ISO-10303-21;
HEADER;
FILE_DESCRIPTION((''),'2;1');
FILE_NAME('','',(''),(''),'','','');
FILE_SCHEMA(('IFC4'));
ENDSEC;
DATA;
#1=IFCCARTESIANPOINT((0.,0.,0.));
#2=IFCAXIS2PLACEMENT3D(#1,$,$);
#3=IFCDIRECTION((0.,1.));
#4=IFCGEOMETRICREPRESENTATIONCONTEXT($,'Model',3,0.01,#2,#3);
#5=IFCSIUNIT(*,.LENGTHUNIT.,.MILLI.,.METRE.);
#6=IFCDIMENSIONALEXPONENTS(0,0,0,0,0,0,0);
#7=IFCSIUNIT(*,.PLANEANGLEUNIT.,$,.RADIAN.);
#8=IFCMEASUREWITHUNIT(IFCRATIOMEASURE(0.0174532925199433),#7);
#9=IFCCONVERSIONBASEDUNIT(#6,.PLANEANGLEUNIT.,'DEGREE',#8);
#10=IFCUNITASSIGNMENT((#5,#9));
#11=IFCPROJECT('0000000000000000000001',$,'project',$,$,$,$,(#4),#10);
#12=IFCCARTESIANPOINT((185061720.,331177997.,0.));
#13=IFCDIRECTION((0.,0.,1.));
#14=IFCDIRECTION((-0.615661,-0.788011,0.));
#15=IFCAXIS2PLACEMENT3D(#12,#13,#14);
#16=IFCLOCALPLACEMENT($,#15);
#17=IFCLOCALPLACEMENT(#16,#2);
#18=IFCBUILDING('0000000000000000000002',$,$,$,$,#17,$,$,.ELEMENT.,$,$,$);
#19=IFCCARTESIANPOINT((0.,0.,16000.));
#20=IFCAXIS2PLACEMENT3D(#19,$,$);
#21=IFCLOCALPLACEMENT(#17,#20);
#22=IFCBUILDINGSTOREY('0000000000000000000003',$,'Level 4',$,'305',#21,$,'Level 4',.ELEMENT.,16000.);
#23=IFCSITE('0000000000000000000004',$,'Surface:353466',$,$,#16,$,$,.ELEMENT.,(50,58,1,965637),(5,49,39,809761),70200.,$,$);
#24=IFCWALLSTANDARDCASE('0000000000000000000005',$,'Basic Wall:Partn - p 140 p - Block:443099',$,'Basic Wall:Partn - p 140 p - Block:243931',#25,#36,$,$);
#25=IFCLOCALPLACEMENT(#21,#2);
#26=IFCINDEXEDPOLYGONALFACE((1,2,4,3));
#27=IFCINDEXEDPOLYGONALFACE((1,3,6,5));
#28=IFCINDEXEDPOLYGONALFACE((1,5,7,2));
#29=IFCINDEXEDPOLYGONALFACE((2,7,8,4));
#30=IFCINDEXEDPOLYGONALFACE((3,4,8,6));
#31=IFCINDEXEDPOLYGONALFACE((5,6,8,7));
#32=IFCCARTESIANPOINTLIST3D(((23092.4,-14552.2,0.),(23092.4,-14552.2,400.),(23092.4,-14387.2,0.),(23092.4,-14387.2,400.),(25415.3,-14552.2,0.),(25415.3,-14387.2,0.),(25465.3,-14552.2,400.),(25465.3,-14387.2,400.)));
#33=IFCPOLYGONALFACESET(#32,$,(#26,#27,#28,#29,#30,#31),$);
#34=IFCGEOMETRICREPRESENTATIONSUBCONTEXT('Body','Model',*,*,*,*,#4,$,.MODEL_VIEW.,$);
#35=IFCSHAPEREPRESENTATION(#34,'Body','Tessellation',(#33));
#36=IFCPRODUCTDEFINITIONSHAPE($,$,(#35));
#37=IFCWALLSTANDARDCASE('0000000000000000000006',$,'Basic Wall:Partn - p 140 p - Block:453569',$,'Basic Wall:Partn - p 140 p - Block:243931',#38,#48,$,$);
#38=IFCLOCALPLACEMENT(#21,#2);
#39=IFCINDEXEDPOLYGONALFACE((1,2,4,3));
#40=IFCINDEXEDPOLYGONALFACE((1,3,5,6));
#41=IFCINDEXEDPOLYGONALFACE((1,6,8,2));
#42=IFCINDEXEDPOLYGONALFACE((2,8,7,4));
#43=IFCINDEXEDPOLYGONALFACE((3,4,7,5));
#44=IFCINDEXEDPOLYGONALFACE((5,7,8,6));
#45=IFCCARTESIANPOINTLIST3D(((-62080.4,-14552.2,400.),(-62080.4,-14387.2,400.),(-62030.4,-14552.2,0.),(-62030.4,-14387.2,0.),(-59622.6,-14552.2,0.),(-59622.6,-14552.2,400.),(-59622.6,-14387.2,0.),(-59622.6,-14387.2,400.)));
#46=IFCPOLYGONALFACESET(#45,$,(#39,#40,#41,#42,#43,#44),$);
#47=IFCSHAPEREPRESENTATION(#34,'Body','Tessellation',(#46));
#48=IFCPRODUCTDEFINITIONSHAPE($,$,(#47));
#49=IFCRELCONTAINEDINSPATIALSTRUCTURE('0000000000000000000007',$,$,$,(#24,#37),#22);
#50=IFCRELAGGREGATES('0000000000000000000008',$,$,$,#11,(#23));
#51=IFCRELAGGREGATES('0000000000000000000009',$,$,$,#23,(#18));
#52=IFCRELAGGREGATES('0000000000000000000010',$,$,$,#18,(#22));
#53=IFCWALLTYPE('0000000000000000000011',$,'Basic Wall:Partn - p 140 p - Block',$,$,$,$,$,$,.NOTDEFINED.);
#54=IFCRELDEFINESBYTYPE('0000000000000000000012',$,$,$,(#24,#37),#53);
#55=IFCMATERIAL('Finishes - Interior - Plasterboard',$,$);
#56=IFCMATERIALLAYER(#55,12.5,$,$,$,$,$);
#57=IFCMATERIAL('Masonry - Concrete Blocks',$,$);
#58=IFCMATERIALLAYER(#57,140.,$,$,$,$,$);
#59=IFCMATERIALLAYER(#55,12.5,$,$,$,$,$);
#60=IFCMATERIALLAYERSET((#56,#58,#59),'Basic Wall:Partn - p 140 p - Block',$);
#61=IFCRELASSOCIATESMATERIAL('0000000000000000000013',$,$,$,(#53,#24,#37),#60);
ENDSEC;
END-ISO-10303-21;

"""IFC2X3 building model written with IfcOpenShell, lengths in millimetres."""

from ifc_helpers import new_model, entity, si_unit, converted_unit, direction, frame, frame_2d, origin, place, context, subcontext, project, spatial, polyline, rectangle, extrude, clip, halfspace, bounded_halfspace, material, layer, layer_set, layer_usage, type_object, element, save


model = new_model("IFC2X3")

# Units and contexts
model_context = context("Model", 3, precision=0.01, world=origin(), true_north=direction((0.0, 1.0)))
body_context = subcontext(model_context, "Body", "Model", "MODEL_VIEW")
ifc_project = project(units=[si_unit("LENGTHUNIT", "METRE", prefix="MILLI"), converted_unit("PLANEANGLEUNIT", "DEGREE", entity("IfcRatioMeasure", 0.0174532925199433), si_unit("PLANEANGLEUNIT", "RADIAN"), dimensions=[0, 0, 0, 0, 0, 0, 0])], contexts=[model_context])

# Site, building, storey
site_placement = place(None, frame((185061720.0, 331177997.0, 0.0), z_axis=(0.0, 0.0, 1.0), x_axis=(-0.615661, -0.788011, 0.0)))
site = spatial("IfcSite", under=ifc_project, at=site_placement, Name="Surface:353466", CompositionType="ELEMENT", RefLatitude=(50, 58, 1, 965637), RefLongitude=(5, 49, 39, 809761), RefElevation=70200.0)
building_placement = place(site_placement, origin())
building = spatial("IfcBuilding", under=site, at=building_placement, CompositionType="ELEMENT")
storey_placement = place(building_placement, frame((0.0, 0.0, 16000.0)))
storey = spatial("IfcBuildingStorey", under=building, at=storey_placement, Name="Level 4", ObjectType="305", LongName="Level 4", CompositionType="ELEMENT", Elevation=16000.0)

# Walls
ifc_material_1 = material(Name="Masonry - Concrete Blocks")
ifc_material_2 = material(Name="Finishes - Interior - Plasterboard")
ifc_layer_1 = layer(ifc_material_2, 12.5)
ifc_layer_2 = layer(ifc_material_1, 140.0)
ifc_layer_3 = layer(ifc_material_2, 12.5)
ifc_layer_set_1 = layer_set([ifc_layer_1, ifc_layer_2, ifc_layer_3], Name="Basic Wall:Partn - p 140 p - Block")
wall_type_1 = type_object("IfcWallType", Name="Basic Wall:Partn - p 140 p - Block", PredefinedType="NOTDEFINED", material=ifc_layer_set_1)
ifc_layer_usage_1 = layer_usage(ifc_layer_set_1, "AXIS2", "POSITIVE", -82.5)
wall_1_placement = place(storey_placement, frame((23092.4, -14469.7, 0.0)))
element("IfcWallStandardCase", 1, at=wall_1_placement, inside=storey, type_object=wall_type_1, material=ifc_layer_usage_1, Name="Basic Wall:Partn - p 140 p - Block:443099", ObjectType="Basic Wall:Partn - p 140 p - Block:243931", context=body_context, shape_type="Clipping", body=[
    clip(clip(clip(extrude(rectangle(XDim=2372.9, YDim=165.0, at=frame_2d((1186.4, 0.0), x_axis=(-1.0, 0.0))), origin(), (0.0, 0.0, 1.0), 400.0), bounded_halfspace(frame((0.0, 82.5, 400.0), z_axis=(0.0, 0.0, -1.0), x_axis=(-1.0, 0.0, 0.0)), True, frame((0.0, 82.5, 400.0)), polyline([(0.0, 0.0), (0.0, -165.0), (2372.9, -165.0), (2372.9, 0.0), (0.0, 0.0)]))), bounded_halfspace(frame((2372.9, -82.5, 400.0), z_axis=(0.992278, 0.0, -0.124035), x_axis=(0.0, 1.0, 0.0)), False, frame((2372.9, -82.5, 400.0), z_axis=(0.992278, 0.0, -0.124035), x_axis=(0.0, 1.0, 0.0)), polyline([(0.0, 0.0), (0.0, -4434.2), (0.0, -4535.0), (0.0, -8465.4), (0.0, -8566.1), (0.0, -12496.5), (165.0, -12496.5), (165.0, 0.0), (0.0, 0.0)]))), halfspace(frame((0.0, 0.0, -12000.0)), True)),
])
ifc_layer_usage_2 = layer_usage(ifc_layer_set_1, "AXIS2", "NEGATIVE", 82.5)
wall_2_placement = place(storey_placement, frame((-59622.6, -14469.7, 0.0), z_axis=(0.0, 0.0, 1.0), x_axis=(-1.0, 0.0, 0.0)))
element("IfcWallStandardCase", 2, at=wall_2_placement, inside=storey, type_object=wall_type_1, material=ifc_layer_usage_2, Name="Basic Wall:Partn - p 140 p - Block:453569", ObjectType="Basic Wall:Partn - p 140 p - Block:243931", context=body_context, shape_type="Clipping", body=[
    clip(clip(clip(extrude(rectangle(XDim=2457.9, YDim=165.0, at=frame_2d((1228.9, 0.0), x_axis=(1.0, 0.0))), origin(), (0.0, 0.0, 1.0), 400.0), bounded_halfspace(frame((0.0, -82.5, 400.0), z_axis=(0.0, 0.0, -1.0), x_axis=(0.0, -1.0, 0.0)), True, frame((0.0, -82.5, 400.0)), polyline([(0.0, 0.0), (2457.9, 0.0), (2457.9, 165.0), (0.0, 165.0), (0.0, 0.0)]))), halfspace(frame((2457.9, -82.5, 400.0), z_axis=(0.992278, 0.0, -0.124035), x_axis=(0.0, 1.0, 0.0)), False)), halfspace(frame((0.0, 0.0, -12000.0)), True)),
])

save(model, "model.ifc")
